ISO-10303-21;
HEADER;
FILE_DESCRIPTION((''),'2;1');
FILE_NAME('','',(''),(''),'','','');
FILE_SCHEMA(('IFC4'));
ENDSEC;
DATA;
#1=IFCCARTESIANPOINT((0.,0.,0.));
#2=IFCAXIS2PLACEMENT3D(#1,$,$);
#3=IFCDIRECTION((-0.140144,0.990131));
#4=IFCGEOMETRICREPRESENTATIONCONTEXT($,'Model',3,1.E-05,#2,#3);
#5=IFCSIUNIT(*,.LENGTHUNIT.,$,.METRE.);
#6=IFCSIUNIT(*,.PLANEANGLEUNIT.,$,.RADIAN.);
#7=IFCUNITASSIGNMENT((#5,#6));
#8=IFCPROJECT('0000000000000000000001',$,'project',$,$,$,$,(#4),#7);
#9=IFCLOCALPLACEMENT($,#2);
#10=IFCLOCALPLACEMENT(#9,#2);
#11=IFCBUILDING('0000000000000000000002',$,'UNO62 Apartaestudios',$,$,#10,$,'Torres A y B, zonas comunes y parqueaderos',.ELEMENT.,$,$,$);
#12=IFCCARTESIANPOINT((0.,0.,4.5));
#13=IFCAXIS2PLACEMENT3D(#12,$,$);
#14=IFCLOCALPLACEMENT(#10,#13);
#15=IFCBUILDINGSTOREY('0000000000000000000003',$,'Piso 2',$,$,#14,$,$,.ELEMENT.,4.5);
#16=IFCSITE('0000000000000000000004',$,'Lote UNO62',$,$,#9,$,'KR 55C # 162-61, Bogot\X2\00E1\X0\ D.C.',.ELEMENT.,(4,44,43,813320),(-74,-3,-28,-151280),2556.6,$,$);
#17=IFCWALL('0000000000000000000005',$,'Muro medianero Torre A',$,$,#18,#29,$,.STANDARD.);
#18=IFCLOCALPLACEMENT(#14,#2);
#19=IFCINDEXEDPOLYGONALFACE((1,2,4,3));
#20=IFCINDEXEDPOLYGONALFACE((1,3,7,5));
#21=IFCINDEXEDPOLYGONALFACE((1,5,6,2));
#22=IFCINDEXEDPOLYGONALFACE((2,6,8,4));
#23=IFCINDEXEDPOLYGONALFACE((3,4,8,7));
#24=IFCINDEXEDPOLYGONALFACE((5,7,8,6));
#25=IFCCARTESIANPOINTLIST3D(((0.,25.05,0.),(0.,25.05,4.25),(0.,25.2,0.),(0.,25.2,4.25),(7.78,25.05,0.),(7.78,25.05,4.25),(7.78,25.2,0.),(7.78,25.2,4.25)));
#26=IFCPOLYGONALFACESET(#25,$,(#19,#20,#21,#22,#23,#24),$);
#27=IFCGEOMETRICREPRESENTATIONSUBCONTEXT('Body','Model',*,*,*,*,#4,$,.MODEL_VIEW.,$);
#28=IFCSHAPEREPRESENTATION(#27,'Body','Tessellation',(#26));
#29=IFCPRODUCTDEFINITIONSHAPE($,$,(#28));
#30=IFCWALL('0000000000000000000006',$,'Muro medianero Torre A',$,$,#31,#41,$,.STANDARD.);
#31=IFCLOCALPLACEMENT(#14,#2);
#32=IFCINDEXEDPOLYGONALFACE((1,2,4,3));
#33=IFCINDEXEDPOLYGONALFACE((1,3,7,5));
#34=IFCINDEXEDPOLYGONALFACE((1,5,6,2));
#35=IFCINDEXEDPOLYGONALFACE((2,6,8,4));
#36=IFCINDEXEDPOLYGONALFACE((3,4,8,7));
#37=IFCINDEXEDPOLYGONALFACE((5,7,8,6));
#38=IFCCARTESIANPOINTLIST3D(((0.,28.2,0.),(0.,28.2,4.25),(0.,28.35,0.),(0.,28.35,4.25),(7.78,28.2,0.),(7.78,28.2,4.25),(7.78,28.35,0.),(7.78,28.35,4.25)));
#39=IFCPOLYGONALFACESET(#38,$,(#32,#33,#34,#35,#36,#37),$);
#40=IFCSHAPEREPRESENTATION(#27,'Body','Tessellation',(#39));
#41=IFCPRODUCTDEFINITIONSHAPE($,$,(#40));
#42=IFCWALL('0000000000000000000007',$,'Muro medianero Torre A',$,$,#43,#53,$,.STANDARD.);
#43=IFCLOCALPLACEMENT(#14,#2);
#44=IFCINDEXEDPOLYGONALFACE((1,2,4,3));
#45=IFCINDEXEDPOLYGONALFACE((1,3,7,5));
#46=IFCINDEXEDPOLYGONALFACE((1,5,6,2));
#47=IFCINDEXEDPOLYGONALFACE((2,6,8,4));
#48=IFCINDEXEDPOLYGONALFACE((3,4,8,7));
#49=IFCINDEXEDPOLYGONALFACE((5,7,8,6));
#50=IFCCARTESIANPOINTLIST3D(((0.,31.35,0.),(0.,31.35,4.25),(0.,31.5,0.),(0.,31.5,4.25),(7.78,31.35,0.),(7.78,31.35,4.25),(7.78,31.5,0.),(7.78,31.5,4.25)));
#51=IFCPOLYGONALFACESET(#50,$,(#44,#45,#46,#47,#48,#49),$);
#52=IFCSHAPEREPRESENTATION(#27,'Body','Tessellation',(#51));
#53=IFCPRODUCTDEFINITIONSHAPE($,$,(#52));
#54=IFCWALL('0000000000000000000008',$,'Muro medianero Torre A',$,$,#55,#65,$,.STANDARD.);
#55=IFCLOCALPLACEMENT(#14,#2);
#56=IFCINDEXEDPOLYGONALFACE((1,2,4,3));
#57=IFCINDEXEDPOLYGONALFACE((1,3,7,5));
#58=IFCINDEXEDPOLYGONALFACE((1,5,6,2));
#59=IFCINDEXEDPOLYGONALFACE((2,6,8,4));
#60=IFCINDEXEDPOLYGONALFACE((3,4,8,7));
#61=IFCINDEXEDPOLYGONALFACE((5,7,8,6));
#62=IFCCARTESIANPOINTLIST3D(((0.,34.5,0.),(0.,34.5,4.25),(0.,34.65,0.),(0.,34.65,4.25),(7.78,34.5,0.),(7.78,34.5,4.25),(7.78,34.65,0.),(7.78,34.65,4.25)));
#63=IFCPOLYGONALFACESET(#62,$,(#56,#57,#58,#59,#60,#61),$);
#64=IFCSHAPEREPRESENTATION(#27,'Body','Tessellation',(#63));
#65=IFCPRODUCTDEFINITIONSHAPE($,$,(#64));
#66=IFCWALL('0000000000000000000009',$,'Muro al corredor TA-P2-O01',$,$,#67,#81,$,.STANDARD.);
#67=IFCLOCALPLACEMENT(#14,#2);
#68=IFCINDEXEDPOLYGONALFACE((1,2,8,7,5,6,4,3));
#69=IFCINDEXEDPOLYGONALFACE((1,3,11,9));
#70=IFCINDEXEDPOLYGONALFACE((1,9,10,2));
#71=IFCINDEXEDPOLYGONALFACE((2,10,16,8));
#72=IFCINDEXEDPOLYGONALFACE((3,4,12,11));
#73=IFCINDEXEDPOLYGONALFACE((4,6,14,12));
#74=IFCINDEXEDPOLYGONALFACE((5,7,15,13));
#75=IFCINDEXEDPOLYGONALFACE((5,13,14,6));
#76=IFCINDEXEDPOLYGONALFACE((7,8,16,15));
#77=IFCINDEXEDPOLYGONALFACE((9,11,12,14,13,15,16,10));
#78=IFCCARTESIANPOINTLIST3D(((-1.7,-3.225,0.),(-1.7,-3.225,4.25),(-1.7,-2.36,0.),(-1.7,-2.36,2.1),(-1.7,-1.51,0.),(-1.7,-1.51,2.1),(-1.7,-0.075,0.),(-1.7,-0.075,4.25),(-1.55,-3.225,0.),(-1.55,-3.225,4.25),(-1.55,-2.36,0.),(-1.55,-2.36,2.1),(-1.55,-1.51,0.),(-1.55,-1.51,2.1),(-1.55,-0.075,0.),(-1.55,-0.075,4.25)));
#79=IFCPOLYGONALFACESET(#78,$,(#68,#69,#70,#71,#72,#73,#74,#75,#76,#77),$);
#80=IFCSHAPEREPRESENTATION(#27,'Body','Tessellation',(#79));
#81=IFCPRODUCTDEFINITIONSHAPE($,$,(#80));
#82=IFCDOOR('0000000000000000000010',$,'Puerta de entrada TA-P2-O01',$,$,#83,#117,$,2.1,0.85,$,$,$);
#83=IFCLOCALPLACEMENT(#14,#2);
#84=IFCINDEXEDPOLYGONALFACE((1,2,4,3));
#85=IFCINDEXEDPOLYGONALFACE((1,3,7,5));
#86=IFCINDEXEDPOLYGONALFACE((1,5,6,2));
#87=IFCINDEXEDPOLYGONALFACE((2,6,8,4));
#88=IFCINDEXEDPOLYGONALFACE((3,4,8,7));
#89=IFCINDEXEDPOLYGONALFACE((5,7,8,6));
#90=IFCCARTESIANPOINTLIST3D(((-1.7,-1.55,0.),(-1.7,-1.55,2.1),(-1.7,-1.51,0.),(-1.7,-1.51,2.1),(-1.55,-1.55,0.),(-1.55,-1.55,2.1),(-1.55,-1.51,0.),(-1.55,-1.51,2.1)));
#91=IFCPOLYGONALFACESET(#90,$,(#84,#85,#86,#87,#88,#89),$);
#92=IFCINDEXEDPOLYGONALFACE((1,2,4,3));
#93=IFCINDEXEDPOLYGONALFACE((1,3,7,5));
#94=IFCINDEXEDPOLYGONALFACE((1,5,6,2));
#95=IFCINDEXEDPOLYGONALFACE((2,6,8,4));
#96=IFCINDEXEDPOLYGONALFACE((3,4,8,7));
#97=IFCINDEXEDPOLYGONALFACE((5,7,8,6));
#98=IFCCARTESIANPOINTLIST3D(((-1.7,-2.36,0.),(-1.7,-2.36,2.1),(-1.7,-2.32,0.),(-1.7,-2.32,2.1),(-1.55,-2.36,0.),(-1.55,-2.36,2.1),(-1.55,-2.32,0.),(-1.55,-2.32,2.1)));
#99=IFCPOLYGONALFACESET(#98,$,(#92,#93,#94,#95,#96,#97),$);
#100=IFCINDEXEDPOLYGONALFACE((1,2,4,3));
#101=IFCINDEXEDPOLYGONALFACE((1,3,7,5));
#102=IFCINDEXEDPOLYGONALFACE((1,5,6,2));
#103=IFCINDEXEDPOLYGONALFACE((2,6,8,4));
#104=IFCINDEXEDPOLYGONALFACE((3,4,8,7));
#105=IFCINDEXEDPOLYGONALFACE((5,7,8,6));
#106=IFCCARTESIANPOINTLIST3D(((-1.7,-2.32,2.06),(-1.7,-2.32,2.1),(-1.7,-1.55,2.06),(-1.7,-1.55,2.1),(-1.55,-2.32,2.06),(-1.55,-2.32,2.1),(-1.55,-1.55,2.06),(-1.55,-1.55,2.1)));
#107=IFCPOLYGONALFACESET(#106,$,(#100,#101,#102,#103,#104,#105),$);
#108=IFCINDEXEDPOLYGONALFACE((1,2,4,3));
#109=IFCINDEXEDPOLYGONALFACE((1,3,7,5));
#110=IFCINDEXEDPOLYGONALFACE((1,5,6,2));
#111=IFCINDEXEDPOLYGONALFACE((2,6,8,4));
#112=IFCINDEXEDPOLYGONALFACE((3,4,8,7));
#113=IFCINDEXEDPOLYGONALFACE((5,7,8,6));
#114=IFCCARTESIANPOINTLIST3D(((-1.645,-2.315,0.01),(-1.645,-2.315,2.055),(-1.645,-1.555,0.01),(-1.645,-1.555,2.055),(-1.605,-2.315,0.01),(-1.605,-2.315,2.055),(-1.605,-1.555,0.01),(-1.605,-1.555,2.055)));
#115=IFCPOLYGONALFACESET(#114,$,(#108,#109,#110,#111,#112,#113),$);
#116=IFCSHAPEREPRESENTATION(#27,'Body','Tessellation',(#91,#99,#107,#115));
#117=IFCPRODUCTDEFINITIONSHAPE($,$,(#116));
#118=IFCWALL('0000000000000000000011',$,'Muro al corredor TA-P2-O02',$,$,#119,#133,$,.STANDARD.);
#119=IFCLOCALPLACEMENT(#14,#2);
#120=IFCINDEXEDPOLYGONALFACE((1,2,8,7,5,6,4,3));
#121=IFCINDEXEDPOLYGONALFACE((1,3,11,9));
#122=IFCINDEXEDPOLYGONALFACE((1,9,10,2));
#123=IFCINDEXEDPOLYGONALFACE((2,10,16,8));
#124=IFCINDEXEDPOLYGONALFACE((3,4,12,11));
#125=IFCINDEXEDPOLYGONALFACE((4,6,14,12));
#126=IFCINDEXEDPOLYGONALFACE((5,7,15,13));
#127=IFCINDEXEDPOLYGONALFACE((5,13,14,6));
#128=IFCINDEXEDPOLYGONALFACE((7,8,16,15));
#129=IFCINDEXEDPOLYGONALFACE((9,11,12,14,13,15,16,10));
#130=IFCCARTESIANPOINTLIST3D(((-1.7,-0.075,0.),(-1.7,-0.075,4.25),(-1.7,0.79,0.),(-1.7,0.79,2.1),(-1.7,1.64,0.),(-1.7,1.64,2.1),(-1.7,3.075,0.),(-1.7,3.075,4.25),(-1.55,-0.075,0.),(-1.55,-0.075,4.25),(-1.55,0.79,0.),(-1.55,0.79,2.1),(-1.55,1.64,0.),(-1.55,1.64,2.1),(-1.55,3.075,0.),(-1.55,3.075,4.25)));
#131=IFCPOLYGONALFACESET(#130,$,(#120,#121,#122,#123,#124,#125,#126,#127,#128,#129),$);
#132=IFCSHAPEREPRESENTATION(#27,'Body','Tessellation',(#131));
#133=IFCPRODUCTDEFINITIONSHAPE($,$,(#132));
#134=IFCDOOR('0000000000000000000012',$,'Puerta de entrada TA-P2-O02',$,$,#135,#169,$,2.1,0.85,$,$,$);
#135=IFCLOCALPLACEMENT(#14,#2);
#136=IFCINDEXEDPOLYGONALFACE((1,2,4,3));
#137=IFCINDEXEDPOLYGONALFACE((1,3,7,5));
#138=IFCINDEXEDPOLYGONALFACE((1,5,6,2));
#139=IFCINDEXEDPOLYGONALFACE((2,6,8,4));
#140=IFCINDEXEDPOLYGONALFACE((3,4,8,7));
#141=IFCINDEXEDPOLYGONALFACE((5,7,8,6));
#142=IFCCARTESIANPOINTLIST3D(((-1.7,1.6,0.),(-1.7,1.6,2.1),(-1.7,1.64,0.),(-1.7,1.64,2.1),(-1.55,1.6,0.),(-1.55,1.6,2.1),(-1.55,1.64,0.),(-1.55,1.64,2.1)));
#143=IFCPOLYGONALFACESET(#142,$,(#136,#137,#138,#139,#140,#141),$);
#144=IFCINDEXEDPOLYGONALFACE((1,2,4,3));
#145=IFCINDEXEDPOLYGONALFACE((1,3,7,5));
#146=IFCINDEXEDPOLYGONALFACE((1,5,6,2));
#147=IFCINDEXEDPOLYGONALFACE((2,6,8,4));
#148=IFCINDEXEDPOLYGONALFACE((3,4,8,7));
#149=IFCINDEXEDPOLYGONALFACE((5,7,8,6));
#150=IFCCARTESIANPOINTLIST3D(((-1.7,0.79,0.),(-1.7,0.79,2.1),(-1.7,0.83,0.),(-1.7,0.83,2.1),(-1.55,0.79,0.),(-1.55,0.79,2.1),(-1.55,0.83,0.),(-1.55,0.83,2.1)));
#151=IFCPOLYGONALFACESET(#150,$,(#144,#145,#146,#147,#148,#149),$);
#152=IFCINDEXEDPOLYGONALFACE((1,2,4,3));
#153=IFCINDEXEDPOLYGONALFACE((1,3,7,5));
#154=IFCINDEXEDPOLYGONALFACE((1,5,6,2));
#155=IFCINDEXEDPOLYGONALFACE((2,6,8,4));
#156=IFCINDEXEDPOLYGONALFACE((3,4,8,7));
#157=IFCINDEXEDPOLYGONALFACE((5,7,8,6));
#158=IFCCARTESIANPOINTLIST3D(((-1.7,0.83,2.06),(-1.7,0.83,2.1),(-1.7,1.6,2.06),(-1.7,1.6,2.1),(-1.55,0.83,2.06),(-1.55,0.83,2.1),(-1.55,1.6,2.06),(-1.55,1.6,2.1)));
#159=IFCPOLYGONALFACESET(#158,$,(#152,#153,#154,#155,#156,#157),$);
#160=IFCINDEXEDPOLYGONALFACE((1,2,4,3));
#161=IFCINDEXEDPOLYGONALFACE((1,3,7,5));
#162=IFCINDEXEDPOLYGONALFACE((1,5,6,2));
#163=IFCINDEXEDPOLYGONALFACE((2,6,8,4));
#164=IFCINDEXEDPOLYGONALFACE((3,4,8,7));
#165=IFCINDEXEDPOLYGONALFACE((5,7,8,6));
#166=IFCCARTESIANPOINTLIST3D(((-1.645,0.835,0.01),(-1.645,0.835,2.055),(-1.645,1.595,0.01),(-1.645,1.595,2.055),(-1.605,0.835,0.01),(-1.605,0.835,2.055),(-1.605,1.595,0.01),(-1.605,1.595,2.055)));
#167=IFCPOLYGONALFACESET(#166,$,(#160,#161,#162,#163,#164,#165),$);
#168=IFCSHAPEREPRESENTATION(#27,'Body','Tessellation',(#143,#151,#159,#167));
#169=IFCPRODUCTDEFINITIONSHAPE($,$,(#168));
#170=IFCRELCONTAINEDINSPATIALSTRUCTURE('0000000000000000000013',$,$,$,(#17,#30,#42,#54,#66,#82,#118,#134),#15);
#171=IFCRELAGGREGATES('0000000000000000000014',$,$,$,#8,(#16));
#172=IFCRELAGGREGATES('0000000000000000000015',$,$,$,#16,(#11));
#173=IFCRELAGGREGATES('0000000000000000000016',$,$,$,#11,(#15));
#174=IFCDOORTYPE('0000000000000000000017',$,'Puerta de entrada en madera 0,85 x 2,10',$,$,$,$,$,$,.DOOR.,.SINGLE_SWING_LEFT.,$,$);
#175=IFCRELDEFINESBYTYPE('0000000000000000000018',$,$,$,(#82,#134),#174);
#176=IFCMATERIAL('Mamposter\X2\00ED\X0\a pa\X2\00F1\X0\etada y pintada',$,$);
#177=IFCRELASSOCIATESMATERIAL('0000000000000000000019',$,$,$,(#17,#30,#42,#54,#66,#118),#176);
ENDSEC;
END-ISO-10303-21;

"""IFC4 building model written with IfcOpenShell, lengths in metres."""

from ifc_helpers import new_model, si_unit, direction, frame, frame_2d, origin, place, context, subcontext, project, spatial, rectangle, extrude, source, transform, mapped, material, type_object, type_shapes, element, fill, save


model = new_model("IFC4")

# Units and contexts
model_context = context("Model", 3, precision=1e-05, world=origin(), true_north=direction((-0.140144, 0.990131)))
body_context = subcontext(model_context, "Body", "Model", "MODEL_VIEW")
ifc_project = project(units=[si_unit("LENGTHUNIT", "METRE"), si_unit("PLANEANGLEUNIT", "RADIAN")], contexts=[model_context])

# Site, building, storey
site_placement = place(None, origin())
site = spatial("IfcSite", under=ifc_project, at=site_placement, Name="Lote UNO62", LongName="KR 55C # 162-61, Bogotá D.C.", CompositionType="ELEMENT", RefLatitude=(4, 44, 43, 813320), RefLongitude=(-74, -3, -28, -151280), RefElevation=2556.6)
building_placement = place(site_placement, origin())
building = spatial("IfcBuilding", under=site, at=building_placement, Name="UNO62 Apartaestudios", LongName="Torres A y B, zonas comunes y parqueaderos", CompositionType="ELEMENT")
storey_placement = place(building_placement, frame((0.0, 0.0, 4.5)))
storey = spatial("IfcBuildingStorey", under=building, at=storey_placement, Name="Piso 2", CompositionType="ELEMENT", Elevation=4.5)

# Walls
ifc_material_1 = material(Name="Mampostería pañetada y pintada")
wall_1_placement = place(storey_placement, origin())
element("IfcWall", 1, at=wall_1_placement, inside=storey, material=ifc_material_1, Name="Muro medianero Torre A", PredefinedType="STANDARD", context=body_context, shape_type="SweptSolid", body=[
    extrude(rectangle(XDim=7.78, YDim=0.15, at=frame_2d((3.89, 25.125))), origin(), (0.0, 0.0, 1.0), 4.25),
])
wall_2_placement = place(storey_placement, origin())
element("IfcWall", 2, at=wall_2_placement, inside=storey, material=ifc_material_1, Name="Muro medianero Torre A", PredefinedType="STANDARD", context=body_context, shape_type="SweptSolid", body=[
    extrude(rectangle(XDim=7.78, YDim=0.15, at=frame_2d((3.89, 28.275))), origin(), (0.0, 0.0, 1.0), 4.25),
])
wall_3_placement = place(storey_placement, origin())
element("IfcWall", 3, at=wall_3_placement, inside=storey, material=ifc_material_1, Name="Muro medianero Torre A", PredefinedType="STANDARD", context=body_context, shape_type="SweptSolid", body=[
    extrude(rectangle(XDim=7.78, YDim=0.15, at=frame_2d((3.89, 31.425))), origin(), (0.0, 0.0, 1.0), 4.25),
])
wall_4_placement = place(storey_placement, origin())
element("IfcWall", 4, at=wall_4_placement, inside=storey, material=ifc_material_1, Name="Muro medianero Torre A", PredefinedType="STANDARD", context=body_context, shape_type="SweptSolid", body=[
    extrude(rectangle(XDim=7.78, YDim=0.15, at=frame_2d((3.89, 34.575))), origin(), (0.0, 0.0, 1.0), 4.25),
])

# Shared definitions
placement_1 = place(storey_placement, frame((-1.7, -0.15, 0.0), z_axis=(0.0, 0.0, 1.0), x_axis=(-1.0, 0.0, 0.0)))
placement_2 = place(storey_placement, frame((-1.7, 3.0, 0.0), z_axis=(0.0, 0.0, 1.0), x_axis=(-1.0, 0.0, 0.0)))

# Walls, openings, doors
wall_5_placement = place(storey_placement, origin())
wall_5 = element("IfcWall", 5, at=wall_5_placement, inside=storey, material=ifc_material_1, Name="Muro al corredor TA-P2-O01", PredefinedType="STANDARD", context=body_context, shape_type="SweptSolid", body=[
    extrude(rectangle(XDim=0.15, YDim=3.15, at=frame_2d((-1.625, -1.65))), origin(), (0.0, 0.0, 1.0), 4.25),
])
opening_1_placement = place(wall_5_placement, origin())
opening_1 = element("IfcOpeningElement", 6, at=opening_1_placement, cuts=wall_5, PredefinedType="OPENING", context=body_context, shape_type="SweptSolid", body=[
    extrude(rectangle(XDim=0.25, YDim=0.85, at=frame_2d((-1.625, -1.935))), origin(), (0.0, 0.0, 1.0), 2.1),
])
door_type_1 = type_object("IfcDoorType", Name="Puerta de entrada en madera 0,85 x 2,10", OperationType="SINGLE_SWING_LEFT", PredefinedType="DOOR")
shared_shape_1 = source(origin(), body_context, "Body", "SweptSolid", [
    extrude(rectangle(XDim=0.15, YDim=0.04, at=frame_2d((-0.075, 1.38))), origin(), (0.0, 0.0, 1.0), 2.1),
    extrude(rectangle(XDim=0.15, YDim=0.04, at=frame_2d((-0.075, 2.19))), origin(), (0.0, 0.0, 1.0), 2.1),
    extrude(rectangle(XDim=0.15, YDim=0.77, at=frame_2d((-0.075, 1.785))), frame((0.0, 0.0, 2.06)), (0.0, 0.0, 1.0), 0.04),
    extrude(rectangle(XDim=0.04, YDim=0.76, at=frame_2d((-0.075, 1.785))), frame((0.0, 0.0, 0.01)), (0.0, 0.0, 1.0), 2.045),
])
type_shapes(door_type_1, [shared_shape_1])
door_1_placement = place(placement_1, origin())
door_1 = element("IfcDoor", 7, at=door_1_placement, inside=storey, type_object=door_type_1, Name="Puerta de entrada TA-P2-O01", OverallHeight=2.1, OverallWidth=0.85, context=body_context, shape_type="MappedRepresentation", body=[
    mapped(shared_shape_1, transform((0.0, 0.0, 0.0))),
])
fill(opening_1, door_1)
wall_6_placement = place(storey_placement, origin())
wall_6 = element("IfcWall", 8, at=wall_6_placement, inside=storey, material=ifc_material_1, Name="Muro al corredor TA-P2-O02", PredefinedType="STANDARD", context=body_context, shape_type="SweptSolid", body=[
    extrude(rectangle(XDim=0.15, YDim=3.15, at=frame_2d((-1.625, 1.5))), origin(), (0.0, 0.0, 1.0), 4.25),
])
opening_2_placement = place(wall_6_placement, origin())
opening_2 = element("IfcOpeningElement", 9, at=opening_2_placement, cuts=wall_6, PredefinedType="OPENING", context=body_context, shape_type="SweptSolid", body=[
    extrude(rectangle(XDim=0.25, YDim=0.85, at=frame_2d((-1.625, 1.215))), origin(), (0.0, 0.0, 1.0), 2.1),
])
door_2_placement = place(placement_2, origin())
door_2 = element("IfcDoor", 10, at=door_2_placement, inside=storey, type_object=door_type_1, Name="Puerta de entrada TA-P2-O02", OverallHeight=2.1, OverallWidth=0.85, context=body_context, shape_type="MappedRepresentation", body=[
    mapped(shared_shape_1, transform((0.0, 0.0, 0.0))),
])
fill(opening_2, door_2)

save(model, "model.ifc")
